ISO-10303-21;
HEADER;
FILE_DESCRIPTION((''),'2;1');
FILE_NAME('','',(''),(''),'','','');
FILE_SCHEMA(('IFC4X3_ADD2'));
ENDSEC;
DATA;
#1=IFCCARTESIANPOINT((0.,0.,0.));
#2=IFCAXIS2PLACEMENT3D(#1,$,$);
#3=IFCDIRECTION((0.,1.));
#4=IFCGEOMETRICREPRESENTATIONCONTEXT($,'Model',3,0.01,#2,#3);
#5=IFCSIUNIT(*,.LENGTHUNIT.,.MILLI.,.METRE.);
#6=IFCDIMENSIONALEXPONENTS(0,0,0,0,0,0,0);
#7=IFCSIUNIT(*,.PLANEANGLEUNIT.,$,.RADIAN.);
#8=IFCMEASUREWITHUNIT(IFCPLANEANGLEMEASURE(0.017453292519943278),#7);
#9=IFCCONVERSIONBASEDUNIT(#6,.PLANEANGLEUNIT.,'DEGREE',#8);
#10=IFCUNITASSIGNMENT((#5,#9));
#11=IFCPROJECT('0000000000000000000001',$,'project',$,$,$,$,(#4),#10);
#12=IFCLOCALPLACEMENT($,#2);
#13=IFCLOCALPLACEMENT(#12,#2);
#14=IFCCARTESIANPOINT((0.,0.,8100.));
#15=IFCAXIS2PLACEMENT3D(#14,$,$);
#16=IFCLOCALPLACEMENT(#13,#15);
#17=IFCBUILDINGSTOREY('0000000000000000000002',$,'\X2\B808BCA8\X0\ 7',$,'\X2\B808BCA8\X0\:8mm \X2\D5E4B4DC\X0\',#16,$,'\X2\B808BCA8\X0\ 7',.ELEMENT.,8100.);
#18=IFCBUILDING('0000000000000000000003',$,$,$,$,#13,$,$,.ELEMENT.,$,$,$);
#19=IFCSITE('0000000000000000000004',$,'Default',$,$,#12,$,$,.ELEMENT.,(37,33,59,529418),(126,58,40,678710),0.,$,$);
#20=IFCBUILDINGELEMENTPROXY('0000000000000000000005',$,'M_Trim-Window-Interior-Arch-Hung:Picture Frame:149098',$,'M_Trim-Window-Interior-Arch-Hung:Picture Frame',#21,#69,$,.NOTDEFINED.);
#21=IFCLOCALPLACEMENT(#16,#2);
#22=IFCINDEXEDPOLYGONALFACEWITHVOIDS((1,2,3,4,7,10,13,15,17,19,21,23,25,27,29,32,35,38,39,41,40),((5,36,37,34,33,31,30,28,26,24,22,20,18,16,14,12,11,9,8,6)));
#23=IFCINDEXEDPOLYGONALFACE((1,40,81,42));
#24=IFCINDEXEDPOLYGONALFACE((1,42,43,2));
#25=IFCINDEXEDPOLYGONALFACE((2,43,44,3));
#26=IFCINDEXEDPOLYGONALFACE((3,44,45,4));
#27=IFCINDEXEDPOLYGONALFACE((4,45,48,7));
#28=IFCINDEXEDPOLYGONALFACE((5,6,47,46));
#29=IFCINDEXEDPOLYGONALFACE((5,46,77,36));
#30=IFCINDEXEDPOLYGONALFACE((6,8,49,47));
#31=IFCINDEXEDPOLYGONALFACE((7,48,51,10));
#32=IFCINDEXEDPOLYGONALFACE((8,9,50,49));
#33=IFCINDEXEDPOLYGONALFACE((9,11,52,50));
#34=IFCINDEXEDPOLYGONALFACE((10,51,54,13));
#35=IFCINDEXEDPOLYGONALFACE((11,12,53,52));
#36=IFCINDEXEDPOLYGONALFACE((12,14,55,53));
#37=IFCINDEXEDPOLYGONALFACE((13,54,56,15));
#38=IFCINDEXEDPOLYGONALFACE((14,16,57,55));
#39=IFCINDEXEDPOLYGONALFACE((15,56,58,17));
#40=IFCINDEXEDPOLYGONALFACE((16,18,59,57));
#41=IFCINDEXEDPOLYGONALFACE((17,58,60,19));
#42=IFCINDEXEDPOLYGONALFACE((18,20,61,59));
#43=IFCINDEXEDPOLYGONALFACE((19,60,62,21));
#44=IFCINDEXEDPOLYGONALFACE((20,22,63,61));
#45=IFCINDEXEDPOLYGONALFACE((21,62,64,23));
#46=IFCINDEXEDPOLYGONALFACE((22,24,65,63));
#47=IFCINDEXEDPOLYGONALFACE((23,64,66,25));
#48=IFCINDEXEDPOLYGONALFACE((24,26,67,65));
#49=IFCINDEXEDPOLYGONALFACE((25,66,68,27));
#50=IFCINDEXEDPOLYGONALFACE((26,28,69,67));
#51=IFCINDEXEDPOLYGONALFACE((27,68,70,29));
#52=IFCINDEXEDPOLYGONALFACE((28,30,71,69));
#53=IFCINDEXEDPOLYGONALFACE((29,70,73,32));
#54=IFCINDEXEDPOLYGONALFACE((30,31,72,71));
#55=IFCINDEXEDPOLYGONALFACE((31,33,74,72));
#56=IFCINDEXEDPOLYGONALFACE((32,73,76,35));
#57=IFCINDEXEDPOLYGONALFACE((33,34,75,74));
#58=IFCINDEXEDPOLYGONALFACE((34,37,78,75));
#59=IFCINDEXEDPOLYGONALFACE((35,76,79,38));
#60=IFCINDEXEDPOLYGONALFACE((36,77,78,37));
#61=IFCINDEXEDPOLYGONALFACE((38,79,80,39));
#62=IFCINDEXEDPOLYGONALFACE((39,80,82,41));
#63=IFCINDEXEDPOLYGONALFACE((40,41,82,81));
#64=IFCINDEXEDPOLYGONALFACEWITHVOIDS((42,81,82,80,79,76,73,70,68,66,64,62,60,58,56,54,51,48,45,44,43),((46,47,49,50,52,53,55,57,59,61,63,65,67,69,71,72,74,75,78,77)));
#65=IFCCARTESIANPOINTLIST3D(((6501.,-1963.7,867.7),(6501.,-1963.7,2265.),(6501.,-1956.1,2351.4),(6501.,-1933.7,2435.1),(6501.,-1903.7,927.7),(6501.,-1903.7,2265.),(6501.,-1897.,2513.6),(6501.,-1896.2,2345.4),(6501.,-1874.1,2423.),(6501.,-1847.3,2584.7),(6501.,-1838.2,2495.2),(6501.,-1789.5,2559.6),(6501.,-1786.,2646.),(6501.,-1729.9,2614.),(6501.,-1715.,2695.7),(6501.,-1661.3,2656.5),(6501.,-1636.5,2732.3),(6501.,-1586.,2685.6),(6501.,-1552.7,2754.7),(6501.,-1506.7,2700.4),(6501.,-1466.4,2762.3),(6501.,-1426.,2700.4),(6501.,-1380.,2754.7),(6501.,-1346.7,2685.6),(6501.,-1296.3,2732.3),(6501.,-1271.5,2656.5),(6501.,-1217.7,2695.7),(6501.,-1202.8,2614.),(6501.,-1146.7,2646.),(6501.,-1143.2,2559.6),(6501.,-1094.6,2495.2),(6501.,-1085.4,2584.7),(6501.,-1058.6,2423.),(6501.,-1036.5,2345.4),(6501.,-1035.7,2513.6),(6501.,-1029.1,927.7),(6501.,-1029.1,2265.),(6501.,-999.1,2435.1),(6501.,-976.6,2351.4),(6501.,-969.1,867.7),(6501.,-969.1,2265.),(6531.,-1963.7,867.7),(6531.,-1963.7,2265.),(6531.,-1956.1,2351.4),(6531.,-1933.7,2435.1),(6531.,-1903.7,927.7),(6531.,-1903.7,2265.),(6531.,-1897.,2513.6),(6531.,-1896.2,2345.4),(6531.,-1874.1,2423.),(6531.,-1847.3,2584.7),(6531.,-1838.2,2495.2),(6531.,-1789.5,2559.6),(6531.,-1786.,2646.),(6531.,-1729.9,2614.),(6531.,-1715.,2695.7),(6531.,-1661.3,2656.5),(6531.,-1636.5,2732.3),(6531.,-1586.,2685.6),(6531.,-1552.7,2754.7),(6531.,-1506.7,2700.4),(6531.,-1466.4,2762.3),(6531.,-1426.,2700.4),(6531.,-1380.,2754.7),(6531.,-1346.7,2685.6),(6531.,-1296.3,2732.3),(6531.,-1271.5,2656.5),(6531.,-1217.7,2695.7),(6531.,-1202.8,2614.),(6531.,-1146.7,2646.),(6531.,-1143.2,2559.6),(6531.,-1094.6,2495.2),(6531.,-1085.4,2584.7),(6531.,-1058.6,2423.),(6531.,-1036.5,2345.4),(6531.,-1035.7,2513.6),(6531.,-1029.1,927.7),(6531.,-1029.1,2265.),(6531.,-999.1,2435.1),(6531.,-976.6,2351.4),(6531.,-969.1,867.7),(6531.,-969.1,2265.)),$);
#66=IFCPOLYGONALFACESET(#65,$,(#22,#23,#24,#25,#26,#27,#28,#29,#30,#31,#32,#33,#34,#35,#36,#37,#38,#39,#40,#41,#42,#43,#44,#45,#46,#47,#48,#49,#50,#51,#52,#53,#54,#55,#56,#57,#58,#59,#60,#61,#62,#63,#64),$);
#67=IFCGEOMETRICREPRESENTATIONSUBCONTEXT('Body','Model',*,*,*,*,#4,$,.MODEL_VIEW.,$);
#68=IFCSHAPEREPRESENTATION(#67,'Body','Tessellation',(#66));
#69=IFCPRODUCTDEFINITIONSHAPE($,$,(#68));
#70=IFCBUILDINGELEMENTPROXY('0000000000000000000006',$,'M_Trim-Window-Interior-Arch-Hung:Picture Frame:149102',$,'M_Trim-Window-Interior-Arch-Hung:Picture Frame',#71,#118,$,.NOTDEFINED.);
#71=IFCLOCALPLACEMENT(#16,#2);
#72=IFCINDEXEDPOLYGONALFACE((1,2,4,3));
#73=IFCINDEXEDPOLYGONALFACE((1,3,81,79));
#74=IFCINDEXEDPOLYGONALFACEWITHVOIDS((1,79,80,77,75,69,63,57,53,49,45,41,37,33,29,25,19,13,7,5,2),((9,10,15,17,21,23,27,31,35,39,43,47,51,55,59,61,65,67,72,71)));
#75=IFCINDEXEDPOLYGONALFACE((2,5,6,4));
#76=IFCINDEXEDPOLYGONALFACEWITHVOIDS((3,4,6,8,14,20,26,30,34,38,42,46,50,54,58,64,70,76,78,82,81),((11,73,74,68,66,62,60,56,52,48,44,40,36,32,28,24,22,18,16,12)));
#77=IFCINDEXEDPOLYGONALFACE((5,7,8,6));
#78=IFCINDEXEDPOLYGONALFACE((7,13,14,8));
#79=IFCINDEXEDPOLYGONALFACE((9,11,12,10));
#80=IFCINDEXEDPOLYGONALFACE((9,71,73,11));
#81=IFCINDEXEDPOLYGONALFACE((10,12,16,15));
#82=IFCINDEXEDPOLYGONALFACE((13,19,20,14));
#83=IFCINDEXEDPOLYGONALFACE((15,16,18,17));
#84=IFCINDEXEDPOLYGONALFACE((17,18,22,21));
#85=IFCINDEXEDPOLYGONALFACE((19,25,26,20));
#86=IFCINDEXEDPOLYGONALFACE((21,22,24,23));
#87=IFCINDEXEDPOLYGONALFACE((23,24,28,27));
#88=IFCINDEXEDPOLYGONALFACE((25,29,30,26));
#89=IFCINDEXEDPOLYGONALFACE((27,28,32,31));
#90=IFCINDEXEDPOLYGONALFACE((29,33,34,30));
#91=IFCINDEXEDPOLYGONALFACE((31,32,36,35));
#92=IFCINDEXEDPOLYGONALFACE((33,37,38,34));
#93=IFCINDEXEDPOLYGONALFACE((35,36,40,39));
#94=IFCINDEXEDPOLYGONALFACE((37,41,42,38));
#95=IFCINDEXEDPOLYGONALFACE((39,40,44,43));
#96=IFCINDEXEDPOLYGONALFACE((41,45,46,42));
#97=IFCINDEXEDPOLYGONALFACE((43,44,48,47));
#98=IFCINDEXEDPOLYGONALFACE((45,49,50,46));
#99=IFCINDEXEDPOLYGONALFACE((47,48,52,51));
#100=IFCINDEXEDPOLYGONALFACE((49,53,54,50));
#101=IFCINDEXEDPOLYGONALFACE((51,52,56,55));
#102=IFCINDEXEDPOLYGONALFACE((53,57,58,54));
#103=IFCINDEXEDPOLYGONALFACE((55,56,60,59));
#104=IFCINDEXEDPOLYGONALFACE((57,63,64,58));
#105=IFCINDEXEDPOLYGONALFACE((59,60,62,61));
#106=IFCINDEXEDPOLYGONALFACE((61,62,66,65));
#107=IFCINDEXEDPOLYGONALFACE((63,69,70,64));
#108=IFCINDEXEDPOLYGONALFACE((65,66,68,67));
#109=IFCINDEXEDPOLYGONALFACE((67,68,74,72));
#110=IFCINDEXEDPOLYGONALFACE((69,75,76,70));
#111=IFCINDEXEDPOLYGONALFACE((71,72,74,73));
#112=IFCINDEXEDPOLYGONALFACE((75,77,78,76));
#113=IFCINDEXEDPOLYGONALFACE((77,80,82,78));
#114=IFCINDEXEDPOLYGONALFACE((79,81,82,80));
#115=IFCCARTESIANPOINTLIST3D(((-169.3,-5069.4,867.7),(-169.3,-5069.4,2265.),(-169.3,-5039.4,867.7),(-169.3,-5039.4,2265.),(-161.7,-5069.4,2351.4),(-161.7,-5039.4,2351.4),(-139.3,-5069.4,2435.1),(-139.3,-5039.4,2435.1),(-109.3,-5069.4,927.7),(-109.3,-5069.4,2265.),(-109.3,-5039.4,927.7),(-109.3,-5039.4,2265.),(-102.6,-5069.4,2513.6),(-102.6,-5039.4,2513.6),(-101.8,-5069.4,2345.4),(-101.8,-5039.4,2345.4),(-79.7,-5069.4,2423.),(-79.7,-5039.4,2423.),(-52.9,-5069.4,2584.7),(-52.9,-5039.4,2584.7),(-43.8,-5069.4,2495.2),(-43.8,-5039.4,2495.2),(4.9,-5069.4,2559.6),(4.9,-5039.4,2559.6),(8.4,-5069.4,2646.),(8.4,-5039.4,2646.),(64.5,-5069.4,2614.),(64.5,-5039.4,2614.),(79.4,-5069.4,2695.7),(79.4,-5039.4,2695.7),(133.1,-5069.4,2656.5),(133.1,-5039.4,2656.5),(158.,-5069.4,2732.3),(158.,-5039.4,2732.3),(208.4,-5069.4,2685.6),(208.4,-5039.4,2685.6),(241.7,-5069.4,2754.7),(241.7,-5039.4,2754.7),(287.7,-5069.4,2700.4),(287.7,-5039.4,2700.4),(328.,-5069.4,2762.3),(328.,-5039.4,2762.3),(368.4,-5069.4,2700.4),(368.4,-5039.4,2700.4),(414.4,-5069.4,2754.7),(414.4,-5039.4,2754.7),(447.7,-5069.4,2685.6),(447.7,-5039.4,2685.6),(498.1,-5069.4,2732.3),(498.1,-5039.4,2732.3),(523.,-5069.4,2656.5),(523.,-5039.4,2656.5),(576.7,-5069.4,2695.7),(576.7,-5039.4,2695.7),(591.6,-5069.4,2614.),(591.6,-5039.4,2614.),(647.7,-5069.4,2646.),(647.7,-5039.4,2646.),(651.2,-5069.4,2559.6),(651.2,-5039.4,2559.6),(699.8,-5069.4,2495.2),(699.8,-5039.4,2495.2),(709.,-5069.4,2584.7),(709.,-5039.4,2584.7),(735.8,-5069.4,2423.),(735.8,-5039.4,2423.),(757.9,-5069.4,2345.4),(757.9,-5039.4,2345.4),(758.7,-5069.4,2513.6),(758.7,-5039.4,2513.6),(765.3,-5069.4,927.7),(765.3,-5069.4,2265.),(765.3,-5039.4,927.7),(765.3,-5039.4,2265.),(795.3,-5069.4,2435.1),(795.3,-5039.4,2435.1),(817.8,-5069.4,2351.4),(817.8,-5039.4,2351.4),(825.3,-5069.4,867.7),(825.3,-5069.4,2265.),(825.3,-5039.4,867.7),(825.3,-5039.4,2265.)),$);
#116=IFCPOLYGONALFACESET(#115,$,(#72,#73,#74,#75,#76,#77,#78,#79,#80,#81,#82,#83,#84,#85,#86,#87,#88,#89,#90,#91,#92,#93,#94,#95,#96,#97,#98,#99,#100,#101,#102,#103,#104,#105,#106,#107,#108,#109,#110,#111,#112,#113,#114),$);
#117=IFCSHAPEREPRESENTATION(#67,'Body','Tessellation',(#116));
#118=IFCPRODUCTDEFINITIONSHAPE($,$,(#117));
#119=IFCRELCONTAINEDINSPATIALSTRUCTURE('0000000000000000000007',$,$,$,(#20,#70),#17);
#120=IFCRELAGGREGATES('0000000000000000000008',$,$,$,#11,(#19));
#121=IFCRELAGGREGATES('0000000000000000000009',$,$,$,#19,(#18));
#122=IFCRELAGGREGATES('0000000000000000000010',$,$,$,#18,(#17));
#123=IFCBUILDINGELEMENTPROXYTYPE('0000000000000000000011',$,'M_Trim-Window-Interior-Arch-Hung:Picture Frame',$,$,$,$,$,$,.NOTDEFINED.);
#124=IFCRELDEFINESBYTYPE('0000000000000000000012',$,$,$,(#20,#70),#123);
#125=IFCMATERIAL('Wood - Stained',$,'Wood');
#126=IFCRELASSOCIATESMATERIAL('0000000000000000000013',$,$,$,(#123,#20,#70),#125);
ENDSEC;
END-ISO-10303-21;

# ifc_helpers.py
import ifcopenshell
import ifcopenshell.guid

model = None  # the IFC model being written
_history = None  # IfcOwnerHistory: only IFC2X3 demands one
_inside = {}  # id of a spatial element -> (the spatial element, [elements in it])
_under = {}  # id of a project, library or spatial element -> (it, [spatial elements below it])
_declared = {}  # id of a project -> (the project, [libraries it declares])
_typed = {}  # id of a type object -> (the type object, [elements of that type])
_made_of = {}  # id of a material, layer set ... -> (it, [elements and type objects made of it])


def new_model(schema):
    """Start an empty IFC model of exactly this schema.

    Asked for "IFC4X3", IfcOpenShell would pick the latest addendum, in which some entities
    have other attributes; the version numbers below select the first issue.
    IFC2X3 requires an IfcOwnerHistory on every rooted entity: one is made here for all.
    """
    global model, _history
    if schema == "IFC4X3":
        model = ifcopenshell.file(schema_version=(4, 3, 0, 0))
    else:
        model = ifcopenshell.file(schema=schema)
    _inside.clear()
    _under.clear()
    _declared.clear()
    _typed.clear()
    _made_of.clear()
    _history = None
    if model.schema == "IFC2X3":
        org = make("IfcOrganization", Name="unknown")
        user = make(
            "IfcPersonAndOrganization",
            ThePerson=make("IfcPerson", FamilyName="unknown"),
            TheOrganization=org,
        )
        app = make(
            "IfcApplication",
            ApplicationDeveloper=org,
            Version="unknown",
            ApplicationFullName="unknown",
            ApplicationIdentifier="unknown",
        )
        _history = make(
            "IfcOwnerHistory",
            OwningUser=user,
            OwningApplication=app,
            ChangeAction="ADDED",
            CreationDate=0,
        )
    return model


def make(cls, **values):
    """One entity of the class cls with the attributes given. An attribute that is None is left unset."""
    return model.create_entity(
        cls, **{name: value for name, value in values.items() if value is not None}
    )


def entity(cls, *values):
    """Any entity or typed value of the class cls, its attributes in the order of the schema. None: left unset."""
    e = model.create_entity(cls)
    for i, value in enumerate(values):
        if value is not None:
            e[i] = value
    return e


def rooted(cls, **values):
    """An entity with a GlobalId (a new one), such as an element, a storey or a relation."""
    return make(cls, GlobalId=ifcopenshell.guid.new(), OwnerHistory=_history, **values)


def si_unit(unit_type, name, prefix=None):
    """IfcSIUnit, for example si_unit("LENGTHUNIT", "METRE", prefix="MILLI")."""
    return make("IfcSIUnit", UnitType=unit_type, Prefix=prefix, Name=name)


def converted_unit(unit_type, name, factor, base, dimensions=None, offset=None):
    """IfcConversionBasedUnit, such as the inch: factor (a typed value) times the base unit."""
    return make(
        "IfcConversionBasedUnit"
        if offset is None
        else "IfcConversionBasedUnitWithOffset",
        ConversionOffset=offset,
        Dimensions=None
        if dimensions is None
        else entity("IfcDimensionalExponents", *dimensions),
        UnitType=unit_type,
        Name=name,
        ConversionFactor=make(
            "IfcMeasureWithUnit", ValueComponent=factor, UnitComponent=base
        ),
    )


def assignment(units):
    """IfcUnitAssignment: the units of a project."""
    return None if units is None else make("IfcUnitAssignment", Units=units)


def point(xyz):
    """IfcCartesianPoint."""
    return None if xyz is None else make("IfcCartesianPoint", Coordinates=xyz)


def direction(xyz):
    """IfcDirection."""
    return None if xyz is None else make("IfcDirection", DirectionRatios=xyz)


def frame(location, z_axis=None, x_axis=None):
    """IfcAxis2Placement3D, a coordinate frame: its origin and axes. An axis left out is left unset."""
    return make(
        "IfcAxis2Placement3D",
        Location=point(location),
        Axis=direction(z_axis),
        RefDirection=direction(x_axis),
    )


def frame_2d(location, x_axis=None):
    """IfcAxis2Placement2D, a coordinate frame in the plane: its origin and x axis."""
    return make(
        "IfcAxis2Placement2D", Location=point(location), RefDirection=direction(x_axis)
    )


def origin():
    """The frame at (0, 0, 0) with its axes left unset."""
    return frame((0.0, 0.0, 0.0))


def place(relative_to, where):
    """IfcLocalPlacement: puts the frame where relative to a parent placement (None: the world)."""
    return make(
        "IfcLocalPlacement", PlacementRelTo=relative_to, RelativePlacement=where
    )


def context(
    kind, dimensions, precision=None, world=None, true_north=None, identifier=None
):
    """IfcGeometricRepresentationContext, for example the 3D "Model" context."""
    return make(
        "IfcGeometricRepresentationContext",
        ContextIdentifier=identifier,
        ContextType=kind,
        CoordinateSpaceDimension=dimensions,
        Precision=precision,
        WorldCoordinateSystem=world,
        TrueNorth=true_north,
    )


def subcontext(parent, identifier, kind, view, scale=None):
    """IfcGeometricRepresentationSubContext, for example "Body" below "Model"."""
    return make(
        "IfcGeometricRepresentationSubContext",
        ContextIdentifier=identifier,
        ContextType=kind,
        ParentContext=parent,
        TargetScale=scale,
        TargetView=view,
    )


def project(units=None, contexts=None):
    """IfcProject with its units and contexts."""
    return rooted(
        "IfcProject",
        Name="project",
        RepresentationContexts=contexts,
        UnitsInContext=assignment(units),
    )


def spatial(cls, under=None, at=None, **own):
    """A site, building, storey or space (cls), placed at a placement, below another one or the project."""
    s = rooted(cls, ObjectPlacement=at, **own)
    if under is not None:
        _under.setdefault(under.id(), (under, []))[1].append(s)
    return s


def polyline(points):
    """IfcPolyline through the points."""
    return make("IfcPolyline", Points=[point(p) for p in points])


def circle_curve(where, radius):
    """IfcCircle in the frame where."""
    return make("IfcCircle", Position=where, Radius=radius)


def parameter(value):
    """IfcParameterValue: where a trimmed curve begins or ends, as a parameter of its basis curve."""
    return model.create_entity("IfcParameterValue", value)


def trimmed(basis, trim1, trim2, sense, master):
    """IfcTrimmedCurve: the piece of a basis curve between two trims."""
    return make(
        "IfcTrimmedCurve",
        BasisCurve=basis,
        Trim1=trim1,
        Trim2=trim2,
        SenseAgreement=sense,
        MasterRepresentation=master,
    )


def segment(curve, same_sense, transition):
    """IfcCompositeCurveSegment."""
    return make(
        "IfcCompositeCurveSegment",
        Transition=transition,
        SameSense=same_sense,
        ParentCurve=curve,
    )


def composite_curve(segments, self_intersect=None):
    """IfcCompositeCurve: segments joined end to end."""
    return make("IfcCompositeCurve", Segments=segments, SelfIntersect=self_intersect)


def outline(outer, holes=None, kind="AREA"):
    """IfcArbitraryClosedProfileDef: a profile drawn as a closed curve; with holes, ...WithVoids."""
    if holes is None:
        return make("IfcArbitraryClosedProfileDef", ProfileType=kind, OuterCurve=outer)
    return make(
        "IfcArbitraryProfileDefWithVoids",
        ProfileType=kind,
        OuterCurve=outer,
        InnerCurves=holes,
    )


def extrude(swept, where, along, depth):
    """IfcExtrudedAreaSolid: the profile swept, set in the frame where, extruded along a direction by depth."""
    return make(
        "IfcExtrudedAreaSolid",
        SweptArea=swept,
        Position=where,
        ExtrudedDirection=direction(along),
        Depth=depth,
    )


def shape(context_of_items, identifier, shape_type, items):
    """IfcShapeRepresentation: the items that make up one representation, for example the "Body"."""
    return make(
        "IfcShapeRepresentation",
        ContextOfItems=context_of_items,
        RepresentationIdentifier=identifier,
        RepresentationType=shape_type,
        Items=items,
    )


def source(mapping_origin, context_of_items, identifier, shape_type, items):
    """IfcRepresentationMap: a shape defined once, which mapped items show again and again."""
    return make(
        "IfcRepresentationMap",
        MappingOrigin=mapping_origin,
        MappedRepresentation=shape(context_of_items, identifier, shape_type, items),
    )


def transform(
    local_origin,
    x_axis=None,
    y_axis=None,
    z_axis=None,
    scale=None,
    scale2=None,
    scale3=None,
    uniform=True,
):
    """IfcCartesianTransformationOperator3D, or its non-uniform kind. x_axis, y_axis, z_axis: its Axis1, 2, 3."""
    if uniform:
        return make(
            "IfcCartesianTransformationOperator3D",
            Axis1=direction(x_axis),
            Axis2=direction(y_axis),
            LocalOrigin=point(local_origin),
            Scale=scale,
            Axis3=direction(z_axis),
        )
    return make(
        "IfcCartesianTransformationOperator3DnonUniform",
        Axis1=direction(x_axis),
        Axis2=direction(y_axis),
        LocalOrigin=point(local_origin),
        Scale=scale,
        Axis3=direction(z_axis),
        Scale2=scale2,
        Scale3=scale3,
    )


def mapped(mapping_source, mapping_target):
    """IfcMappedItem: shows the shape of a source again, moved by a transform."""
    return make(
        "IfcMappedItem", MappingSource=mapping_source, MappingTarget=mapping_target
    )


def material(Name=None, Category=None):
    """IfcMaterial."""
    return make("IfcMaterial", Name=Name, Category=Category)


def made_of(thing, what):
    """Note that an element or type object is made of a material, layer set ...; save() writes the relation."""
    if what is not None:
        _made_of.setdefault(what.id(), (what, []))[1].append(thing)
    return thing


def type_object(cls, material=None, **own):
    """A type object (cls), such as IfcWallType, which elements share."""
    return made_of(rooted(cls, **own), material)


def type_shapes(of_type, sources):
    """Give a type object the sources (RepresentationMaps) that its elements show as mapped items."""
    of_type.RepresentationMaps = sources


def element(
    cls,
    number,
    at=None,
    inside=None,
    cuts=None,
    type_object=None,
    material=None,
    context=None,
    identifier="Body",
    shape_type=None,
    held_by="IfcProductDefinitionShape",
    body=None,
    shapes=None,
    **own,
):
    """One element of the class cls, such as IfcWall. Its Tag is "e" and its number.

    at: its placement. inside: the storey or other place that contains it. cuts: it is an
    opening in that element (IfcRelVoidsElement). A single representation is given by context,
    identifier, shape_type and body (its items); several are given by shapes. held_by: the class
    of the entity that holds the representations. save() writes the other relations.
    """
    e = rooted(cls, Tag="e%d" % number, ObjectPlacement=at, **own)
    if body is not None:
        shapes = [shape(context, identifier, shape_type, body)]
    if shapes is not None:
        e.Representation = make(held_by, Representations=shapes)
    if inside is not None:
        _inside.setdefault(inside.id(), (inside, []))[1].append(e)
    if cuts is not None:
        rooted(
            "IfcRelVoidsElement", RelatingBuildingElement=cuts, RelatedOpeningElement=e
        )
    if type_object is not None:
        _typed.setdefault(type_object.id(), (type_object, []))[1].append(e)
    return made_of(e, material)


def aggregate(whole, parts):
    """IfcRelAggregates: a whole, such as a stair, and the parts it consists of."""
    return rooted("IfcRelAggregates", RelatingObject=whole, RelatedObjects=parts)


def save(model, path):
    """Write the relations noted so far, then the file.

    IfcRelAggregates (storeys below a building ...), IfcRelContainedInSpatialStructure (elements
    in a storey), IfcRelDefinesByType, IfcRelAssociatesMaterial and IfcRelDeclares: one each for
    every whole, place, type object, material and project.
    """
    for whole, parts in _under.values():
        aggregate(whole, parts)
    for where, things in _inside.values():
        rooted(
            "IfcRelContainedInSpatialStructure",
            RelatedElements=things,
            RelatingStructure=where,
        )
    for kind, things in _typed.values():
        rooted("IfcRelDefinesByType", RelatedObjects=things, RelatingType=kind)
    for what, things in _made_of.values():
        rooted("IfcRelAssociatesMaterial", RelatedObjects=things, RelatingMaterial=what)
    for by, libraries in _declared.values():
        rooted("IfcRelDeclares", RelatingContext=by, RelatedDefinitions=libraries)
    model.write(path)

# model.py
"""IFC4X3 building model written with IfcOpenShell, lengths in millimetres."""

from ifc_helpers import new_model, entity, si_unit, converted_unit, direction, frame, frame_2d, origin, place, context, subcontext, project, spatial, polyline, circle_curve, parameter, trimmed, segment, composite_curve, outline, extrude, source, transform, mapped, material, type_object, type_shapes, element, save


model = new_model("IFC4X3")

# Units and contexts
model_context = context("Model", 3, precision=0.01, world=origin(), true_north=direction((0.0, 1.0)))
body_context = subcontext(model_context, "Body", "Model", "MODEL_VIEW")
ifc_project = project(units=[si_unit("LENGTHUNIT", "METRE", prefix="MILLI"), converted_unit("PLANEANGLEUNIT", "DEGREE", entity("IfcPlaneAngleMeasure", 0.017453292519943278), si_unit("PLANEANGLEUNIT", "RADIAN"), dimensions=[0, 0, 0, 0, 0, 0, 0])], contexts=[model_context])

# Site, building, storey
site_placement = place(None, origin())
site = spatial("IfcSite", under=ifc_project, at=site_placement, Name="Default", CompositionType="ELEMENT", RefLatitude=(37, 33, 59, 529418), RefLongitude=(126, 58, 40, 678710), RefElevation=0.0)
building_placement = place(site_placement, origin())
building = spatial("IfcBuilding", under=site, at=building_placement, CompositionType="ELEMENT")
storey_placement = place(building_placement, frame((0.0, 0.0, 8100.0)))
storey = spatial("IfcBuildingStorey", under=building, at=storey_placement, Name="레벨 7", ObjectType="레벨:8mm 헤드", LongName="레벨 7", CompositionType="ELEMENT", Elevation=8100.0)

# Building element proxies
ifc_material_1 = material(Name="Wood - Stained", Category="Wood")
building_element_proxy_type_1 = type_object("IfcBuildingElementProxyType", Name="M_Trim-Window-Interior-Arch-Hung:Picture Frame", PredefinedType="NOTDEFINED", material=ifc_material_1)
shared_shape_1 = source(origin(), body_context, "Body", "SweptSolid", [
    extrude(outline(composite_curve([segment(polyline([(-698.7, -497.3), (698.7, -497.3)]), True, "CONTINUOUS"), segment(polyline([(698.7, -497.3), (698.7, 497.3)]), True, "CONTINUOUS"), segment(polyline([(698.7, 497.3), (-698.7, 497.3)]), True, "CONTINUOUS"), segment(trimmed(circle_curve(frame_2d((-698.7, 0.0), x_axis=(0.0, 1.0)), 497.3), [parameter(0.0)], [parameter(180.0)], True, "PARAMETER"), True, "CONTINUOUS")], self_intersect=False), holes=[composite_curve([segment(trimmed(circle_curve(frame_2d((-698.7, 0.0), x_axis=(0.0, 1.0)), 437.3), [parameter(0.0)], [parameter(180.0)], True, "PARAMETER"), False, "CONTINUOUS"), segment(polyline([(-698.7, 437.3), (638.6, 437.3)]), True, "CONTINUOUS"), segment(polyline([(638.6, 437.3), (638.7, -437.3)]), True, "CONTINUOUS"), segment(polyline([(638.7, -437.3), (-698.7, -437.3)]), True, "CONTINUOUS")], self_intersect=False)]), frame((0.0, -1148.7, 0.0), z_axis=(0.0, 0.0, 1.0), x_axis=(0.0, -1.0, 0.0)), (0.0, 0.0, 1.0), 30.0),
])
type_shapes(building_element_proxy_type_1, [shared_shape_1])
for number, where, z_axis, x_axis, name in (
    (1, (6531.0, -1466.4, 2715.0), (-1.0, 0.0, 0.0), (0.0, -1.0, 0.0), "M_Trim-Window-Interior-Arch-Hung:Picture Frame:149098"),
    (2, (328.0, -5069.4, 2715.0), (0.0, 1.0, 0.0), (-1.0, 0.0, 0.0), "M_Trim-Window-Interior-Arch-Hung:Picture Frame:149102"),
):
    element("IfcBuildingElementProxy", number, at=place(storey_placement, frame(where, z_axis=z_axis, x_axis=x_axis)), inside=storey, type_object=building_element_proxy_type_1, material=ifc_material_1, Name=name, ObjectType="M_Trim-Window-Interior-Arch-Hung:Picture Frame", PredefinedType="NOTDEFINED", context=body_context, shape_type="MappedRepresentation", body=[
        mapped(shared_shape_1, transform((0.0, 0.0, 0.0), scale=1.0)),
    ])

save(model, "model.ifc")
